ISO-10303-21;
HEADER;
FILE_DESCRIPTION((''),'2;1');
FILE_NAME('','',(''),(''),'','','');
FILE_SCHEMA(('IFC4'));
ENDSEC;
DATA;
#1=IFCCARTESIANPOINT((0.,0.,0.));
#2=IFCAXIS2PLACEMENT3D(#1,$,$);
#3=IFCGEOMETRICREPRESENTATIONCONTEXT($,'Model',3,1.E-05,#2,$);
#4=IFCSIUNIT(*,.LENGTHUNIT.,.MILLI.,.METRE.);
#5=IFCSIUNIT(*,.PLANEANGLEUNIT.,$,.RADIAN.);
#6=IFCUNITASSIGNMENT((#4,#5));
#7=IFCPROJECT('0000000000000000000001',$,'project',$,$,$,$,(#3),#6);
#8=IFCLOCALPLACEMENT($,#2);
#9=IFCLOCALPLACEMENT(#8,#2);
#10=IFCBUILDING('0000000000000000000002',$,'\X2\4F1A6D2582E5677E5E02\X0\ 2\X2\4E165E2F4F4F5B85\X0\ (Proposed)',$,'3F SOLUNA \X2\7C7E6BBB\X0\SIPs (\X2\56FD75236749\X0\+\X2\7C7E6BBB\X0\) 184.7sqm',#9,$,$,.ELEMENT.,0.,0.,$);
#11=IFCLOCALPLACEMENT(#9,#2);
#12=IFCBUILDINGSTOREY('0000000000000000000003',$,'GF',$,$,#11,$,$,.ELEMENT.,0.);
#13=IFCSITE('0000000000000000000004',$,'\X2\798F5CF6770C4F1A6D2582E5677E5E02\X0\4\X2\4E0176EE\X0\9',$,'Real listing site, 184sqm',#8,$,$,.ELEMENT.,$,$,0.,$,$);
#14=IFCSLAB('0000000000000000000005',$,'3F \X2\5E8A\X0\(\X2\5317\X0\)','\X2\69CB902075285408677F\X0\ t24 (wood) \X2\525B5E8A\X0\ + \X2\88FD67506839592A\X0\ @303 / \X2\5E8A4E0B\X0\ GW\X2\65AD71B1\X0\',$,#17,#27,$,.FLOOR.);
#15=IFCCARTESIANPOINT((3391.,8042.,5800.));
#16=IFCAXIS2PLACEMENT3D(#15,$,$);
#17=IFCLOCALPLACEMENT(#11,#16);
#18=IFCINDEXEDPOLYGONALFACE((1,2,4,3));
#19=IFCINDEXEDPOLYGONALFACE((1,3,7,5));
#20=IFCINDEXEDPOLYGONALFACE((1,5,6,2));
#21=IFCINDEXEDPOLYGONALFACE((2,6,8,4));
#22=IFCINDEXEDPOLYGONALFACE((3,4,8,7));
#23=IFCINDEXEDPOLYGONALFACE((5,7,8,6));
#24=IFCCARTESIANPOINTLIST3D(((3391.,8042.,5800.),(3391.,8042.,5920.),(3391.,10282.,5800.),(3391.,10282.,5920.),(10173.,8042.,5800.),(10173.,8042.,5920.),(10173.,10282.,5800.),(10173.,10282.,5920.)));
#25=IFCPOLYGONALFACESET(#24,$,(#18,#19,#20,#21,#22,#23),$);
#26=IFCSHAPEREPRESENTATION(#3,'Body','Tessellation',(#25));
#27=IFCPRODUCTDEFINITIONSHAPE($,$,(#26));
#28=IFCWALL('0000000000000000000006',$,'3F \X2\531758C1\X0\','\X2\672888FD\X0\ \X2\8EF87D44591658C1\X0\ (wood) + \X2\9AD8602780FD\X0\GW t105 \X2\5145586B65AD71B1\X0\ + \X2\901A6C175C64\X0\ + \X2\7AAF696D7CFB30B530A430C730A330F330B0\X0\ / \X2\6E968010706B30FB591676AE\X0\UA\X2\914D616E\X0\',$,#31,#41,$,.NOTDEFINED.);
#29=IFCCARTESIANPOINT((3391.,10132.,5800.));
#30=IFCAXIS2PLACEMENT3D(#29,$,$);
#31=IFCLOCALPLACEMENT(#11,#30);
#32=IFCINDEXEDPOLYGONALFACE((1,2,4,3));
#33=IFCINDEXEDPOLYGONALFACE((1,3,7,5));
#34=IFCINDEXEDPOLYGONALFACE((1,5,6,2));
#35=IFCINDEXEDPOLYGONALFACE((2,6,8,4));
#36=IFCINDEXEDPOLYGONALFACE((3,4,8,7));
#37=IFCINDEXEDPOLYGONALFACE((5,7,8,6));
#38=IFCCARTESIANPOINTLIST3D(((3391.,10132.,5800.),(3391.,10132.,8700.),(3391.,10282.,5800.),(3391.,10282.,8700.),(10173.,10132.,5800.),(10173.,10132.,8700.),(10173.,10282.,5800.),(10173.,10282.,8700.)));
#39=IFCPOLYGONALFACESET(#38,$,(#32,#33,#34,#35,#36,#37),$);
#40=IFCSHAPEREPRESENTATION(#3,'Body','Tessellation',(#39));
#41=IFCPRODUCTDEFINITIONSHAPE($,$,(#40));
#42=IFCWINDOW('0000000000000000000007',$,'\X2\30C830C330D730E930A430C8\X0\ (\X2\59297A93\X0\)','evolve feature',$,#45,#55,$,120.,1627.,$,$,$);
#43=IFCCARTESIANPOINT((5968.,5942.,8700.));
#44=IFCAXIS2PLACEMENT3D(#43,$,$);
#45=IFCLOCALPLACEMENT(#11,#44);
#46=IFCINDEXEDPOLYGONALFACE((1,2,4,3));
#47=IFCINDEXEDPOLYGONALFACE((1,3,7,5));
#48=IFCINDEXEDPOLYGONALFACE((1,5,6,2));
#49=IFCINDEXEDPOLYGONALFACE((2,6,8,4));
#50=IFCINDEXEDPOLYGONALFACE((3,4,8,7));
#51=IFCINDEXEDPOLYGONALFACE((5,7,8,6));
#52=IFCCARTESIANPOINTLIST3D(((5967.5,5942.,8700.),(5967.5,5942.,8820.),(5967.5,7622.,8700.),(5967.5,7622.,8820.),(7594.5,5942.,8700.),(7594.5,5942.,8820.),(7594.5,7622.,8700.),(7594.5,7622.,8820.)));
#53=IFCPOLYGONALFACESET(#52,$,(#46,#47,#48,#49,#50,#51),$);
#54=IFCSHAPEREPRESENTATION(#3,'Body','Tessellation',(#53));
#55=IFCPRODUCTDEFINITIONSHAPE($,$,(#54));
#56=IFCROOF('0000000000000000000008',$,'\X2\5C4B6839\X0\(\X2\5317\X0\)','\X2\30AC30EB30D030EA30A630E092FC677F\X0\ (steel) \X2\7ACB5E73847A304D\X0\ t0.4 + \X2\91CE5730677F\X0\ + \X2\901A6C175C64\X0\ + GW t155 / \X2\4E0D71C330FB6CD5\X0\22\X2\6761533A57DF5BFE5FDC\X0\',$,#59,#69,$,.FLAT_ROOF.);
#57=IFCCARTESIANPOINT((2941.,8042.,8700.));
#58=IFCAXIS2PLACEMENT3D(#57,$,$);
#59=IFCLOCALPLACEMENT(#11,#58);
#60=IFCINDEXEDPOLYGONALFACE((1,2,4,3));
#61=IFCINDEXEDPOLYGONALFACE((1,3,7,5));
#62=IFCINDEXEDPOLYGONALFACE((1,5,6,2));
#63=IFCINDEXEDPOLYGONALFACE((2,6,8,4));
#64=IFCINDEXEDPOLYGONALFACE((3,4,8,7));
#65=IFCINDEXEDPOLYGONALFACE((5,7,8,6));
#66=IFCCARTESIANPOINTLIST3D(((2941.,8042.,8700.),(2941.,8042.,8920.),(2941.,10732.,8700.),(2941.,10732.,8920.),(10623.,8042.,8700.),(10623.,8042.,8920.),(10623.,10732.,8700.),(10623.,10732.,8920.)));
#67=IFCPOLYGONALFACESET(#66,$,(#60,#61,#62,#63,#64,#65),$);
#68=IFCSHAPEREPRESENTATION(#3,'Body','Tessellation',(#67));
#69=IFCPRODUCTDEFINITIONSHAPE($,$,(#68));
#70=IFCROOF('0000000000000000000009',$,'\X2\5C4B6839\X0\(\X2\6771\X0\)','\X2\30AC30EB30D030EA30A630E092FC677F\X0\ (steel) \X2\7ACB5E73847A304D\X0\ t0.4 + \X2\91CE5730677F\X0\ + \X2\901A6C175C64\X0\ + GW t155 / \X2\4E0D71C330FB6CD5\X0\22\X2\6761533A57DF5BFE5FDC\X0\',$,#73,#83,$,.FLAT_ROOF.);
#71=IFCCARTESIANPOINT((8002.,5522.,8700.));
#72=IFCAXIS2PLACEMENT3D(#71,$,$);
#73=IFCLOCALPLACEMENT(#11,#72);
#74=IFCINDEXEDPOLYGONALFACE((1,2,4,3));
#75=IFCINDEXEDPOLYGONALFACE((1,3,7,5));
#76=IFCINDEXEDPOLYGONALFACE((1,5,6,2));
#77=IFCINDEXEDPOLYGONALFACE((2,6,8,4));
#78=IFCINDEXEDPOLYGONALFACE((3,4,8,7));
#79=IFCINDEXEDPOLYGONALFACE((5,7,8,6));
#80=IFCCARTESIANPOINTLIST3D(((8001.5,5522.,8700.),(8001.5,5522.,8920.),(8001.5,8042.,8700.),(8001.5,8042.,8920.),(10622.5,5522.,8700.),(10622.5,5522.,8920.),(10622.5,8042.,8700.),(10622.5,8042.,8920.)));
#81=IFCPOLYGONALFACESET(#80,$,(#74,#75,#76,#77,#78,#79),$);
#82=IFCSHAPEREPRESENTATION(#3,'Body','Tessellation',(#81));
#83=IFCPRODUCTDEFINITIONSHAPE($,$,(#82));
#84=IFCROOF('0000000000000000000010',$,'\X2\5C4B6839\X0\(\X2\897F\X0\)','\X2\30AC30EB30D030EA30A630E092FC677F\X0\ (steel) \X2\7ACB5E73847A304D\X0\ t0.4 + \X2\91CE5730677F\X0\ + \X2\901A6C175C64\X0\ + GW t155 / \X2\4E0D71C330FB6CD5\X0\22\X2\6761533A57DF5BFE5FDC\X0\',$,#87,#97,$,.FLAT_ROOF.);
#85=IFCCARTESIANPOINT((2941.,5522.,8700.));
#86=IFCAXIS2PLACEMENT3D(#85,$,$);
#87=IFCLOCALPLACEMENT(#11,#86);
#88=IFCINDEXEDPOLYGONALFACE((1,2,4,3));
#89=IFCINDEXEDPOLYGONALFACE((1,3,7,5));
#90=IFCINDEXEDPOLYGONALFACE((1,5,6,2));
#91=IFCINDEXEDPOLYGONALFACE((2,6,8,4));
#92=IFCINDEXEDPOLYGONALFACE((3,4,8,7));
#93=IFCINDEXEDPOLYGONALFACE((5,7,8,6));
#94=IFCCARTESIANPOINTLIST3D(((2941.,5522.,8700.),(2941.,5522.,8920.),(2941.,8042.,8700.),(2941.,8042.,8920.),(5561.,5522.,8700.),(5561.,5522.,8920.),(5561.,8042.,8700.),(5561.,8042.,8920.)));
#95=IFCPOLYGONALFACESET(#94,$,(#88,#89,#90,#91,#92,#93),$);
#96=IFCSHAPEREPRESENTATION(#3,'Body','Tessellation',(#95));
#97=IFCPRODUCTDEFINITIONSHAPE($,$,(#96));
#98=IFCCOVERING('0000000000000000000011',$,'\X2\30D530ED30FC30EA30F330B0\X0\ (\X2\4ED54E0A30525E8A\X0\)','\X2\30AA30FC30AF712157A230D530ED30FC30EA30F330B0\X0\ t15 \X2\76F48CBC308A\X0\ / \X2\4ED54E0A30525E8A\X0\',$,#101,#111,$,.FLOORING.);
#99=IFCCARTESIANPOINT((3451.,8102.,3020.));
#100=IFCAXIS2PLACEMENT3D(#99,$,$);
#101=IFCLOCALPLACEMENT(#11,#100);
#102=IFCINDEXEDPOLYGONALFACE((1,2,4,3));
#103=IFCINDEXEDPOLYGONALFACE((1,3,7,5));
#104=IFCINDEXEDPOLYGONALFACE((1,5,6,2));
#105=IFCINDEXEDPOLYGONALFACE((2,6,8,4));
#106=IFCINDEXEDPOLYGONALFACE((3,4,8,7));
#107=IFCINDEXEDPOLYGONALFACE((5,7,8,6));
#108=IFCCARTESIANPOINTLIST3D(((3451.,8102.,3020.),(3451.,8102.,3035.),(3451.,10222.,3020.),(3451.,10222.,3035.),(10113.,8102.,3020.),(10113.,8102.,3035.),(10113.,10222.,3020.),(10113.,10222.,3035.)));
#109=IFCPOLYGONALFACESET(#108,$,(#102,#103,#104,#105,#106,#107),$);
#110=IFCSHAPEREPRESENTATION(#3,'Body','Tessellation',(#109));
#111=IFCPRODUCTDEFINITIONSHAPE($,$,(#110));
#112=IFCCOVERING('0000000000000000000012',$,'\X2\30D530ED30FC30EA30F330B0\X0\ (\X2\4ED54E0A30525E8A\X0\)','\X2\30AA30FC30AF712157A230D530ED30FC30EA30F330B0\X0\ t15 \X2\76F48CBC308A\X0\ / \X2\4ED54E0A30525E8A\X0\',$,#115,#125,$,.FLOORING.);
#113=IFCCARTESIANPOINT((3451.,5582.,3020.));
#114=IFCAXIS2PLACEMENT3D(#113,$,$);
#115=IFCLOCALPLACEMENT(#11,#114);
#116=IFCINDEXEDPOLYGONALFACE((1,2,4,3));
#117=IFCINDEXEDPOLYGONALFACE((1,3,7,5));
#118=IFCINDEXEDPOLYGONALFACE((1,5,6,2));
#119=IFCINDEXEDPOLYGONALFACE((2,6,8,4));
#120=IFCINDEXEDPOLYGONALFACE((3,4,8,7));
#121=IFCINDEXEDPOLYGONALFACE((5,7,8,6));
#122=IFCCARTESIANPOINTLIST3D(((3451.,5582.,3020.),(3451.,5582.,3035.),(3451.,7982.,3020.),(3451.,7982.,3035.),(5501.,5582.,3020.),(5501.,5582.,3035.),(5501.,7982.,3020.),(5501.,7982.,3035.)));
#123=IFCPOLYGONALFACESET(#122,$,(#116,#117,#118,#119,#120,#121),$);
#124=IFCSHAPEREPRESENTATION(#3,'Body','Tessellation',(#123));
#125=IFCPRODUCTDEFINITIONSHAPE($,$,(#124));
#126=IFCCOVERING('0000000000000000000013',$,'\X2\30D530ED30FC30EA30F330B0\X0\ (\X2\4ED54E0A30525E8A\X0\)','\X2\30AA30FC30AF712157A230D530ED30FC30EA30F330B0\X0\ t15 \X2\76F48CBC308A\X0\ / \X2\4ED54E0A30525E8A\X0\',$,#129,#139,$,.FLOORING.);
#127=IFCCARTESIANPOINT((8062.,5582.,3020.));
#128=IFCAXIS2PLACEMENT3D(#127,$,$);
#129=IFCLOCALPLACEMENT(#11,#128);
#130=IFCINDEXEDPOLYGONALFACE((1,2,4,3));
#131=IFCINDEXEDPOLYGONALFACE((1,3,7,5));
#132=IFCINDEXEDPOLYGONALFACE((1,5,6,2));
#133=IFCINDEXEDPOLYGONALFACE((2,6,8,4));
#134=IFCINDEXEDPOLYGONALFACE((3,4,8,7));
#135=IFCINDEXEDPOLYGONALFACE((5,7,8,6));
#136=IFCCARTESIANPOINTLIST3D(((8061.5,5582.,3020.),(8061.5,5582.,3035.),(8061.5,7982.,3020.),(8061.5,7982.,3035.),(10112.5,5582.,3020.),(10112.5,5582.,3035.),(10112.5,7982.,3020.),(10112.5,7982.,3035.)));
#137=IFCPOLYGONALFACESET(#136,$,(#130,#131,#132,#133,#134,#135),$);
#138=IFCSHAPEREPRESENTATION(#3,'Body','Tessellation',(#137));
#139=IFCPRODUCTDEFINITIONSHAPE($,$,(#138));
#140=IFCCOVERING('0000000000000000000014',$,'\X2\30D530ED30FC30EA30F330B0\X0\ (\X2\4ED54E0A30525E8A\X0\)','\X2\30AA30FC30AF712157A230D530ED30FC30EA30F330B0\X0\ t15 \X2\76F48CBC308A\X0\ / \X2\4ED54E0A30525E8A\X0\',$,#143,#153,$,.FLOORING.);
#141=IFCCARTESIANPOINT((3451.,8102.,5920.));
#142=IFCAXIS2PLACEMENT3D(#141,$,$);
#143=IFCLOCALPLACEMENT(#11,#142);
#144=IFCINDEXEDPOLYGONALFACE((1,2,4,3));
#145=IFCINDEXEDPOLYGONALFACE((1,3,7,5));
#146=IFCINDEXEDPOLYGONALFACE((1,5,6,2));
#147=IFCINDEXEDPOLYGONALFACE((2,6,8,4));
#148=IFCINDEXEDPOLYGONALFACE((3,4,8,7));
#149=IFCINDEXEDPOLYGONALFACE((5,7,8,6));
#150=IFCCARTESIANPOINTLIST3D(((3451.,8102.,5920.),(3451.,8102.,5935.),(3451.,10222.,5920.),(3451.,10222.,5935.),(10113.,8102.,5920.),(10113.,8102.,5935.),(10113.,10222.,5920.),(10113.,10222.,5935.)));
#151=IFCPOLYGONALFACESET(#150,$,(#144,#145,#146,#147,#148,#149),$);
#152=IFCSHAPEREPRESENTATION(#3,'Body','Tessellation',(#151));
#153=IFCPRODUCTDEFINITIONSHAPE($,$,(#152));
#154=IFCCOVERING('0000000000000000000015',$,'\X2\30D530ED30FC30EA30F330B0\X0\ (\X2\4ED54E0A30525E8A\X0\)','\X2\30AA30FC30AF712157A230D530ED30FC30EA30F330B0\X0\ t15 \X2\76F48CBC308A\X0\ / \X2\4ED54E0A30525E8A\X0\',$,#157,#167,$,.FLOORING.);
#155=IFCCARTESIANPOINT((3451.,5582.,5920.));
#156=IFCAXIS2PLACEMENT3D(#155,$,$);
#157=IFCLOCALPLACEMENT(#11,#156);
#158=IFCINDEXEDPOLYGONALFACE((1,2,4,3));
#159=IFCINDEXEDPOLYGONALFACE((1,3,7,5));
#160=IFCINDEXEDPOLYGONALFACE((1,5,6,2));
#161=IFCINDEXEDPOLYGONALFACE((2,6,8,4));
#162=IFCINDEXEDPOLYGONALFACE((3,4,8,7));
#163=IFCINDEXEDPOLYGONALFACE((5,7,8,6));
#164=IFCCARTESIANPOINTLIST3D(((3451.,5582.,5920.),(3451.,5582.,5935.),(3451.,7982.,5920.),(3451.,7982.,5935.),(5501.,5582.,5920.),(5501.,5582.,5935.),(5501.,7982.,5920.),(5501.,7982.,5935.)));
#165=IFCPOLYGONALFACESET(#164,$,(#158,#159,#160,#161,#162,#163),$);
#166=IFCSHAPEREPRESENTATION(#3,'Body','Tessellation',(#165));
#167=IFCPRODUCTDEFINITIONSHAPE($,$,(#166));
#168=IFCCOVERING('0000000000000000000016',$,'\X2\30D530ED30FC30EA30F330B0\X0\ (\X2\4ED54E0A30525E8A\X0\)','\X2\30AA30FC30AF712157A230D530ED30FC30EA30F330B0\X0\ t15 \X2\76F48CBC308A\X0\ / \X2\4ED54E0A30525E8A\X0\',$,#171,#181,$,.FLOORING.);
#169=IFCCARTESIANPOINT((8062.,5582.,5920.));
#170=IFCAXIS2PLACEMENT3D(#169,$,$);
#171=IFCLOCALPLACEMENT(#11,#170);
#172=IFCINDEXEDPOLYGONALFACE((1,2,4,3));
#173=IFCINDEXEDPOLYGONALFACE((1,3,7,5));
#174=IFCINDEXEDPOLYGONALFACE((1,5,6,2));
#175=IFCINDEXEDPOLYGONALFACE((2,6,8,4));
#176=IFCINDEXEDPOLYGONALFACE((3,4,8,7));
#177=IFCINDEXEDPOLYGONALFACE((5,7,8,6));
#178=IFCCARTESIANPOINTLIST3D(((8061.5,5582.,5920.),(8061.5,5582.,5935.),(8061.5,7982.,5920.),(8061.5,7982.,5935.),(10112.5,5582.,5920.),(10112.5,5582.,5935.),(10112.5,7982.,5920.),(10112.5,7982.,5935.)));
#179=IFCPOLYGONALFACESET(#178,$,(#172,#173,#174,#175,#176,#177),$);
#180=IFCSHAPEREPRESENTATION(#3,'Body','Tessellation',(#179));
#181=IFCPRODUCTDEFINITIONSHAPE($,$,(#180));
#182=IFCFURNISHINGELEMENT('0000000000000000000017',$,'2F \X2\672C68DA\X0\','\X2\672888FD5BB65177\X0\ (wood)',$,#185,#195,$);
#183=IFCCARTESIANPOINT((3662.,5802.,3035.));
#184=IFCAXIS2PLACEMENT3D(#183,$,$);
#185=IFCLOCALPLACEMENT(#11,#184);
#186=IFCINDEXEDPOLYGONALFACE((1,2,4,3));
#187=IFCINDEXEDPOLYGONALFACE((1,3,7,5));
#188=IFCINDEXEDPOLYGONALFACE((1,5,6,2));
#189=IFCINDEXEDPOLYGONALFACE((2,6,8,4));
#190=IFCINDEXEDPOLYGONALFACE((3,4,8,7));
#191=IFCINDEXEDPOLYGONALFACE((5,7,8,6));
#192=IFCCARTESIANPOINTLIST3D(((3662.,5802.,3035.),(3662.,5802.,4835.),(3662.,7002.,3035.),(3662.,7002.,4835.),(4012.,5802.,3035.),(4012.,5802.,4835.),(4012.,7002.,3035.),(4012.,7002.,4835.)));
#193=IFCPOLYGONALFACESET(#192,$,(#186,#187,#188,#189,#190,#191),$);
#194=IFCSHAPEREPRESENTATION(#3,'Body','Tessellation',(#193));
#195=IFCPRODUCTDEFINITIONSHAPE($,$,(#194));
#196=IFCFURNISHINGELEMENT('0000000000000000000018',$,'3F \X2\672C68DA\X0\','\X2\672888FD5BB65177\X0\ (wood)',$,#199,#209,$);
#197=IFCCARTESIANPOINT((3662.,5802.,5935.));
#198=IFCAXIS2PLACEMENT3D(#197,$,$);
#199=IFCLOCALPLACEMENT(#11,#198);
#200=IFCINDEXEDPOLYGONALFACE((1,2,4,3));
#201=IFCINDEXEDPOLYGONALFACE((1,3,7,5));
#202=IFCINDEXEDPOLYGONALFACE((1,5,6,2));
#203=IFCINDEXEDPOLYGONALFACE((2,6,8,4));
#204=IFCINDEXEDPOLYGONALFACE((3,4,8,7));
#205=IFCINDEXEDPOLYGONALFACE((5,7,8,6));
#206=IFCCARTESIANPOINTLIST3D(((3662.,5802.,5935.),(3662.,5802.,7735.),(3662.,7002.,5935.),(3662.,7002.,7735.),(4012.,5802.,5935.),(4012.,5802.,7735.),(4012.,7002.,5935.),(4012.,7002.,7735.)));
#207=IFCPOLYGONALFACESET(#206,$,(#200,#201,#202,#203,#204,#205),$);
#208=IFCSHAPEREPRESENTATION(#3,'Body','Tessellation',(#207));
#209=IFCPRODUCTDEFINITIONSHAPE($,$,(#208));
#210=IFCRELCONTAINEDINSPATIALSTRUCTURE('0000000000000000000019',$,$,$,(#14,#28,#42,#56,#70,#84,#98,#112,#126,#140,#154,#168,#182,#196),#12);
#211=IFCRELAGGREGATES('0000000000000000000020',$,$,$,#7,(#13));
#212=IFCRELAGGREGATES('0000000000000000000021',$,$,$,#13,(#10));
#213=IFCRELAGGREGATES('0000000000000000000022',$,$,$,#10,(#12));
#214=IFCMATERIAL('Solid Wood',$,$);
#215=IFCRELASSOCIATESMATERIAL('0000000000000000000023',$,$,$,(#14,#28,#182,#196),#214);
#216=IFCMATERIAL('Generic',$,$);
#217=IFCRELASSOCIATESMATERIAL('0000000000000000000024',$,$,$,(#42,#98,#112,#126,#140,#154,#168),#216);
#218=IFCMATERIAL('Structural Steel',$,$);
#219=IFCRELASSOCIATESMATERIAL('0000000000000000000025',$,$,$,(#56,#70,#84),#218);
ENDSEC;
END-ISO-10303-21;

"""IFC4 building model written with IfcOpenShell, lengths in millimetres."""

from ifc_helpers import new_model, si_unit, frame, frame_2d, origin, place, context, project, spatial, rectangle, extrude, material, element, save


model = new_model("IFC4")

# Units and contexts
model_context = context("Model", 3, precision=1e-05, world=origin())
ifc_project = project(units=[si_unit("LENGTHUNIT", "METRE", prefix="MILLI"), si_unit("PLANEANGLEUNIT", "RADIAN")], contexts=[model_context])

# Site, building, storey
site_placement = place(None, origin())
site = spatial("IfcSite", under=ifc_project, at=site_placement, Name="福島県会津若松市4丁目9", ObjectType="Real listing site, 184sqm", CompositionType="ELEMENT", RefElevation=0.0)
building_placement = place(site_placement, origin())
building = spatial("IfcBuilding", under=site, at=building_placement, Name="会津若松市 2世帯住宅 (Proposed)", ObjectType="3F SOLUNA 籾殻SIPs (国産杉+籾殻) 184.7sqm", CompositionType="ELEMENT", ElevationOfRefHeight=0.0, ElevationOfTerrain=0.0)
storey_placement = place(building_placement, origin())
storey = spatial("IfcBuildingStorey", under=building, at=storey_placement, Name="GF", CompositionType="ELEMENT", Elevation=0.0)

# Slab
ifc_material_1 = material(Name="Solid Wood")
slab_placement = place(storey_placement, frame((3391.0, 8042.0, 5800.0)))
element("IfcSlab", 1, at=slab_placement, inside=storey, material=ifc_material_1, Name="3F 床(北)", Description="構造用合板 t24 (wood) 剛床 + 製材根太 @303 / 床下 GW断熱", PredefinedType="FLOOR", context=model_context, shape_type="SweptSolid", body=[
    extrude(rectangle(XDim=6782.0, YDim=2240.0, at=frame_2d((3391.0, 1120.0))), frame((3391.0, 8042.0, 5800.0)), (0.0, 0.0, 1.0), 120.0),
])

# Wall
wall_1_placement = place(storey_placement, frame((3391.0, 10132.0, 5800.0)))
element("IfcWall", 2, at=wall_1_placement, inside=storey, material=ifc_material_1, Name="3F 北壁", Description="木製 軸組外壁 (wood) + 高性能GW t105 充填断熱 + 通気層 + 窯業系サイディング / 準耐火・外皮UA配慮", PredefinedType="NOTDEFINED", context=model_context, shape_type="SweptSolid", body=[
    extrude(rectangle(XDim=6782.0, YDim=150.0, at=frame_2d((3391.0, 75.0))), frame((3391.0, 10132.0, 5800.0)), (0.0, 0.0, 1.0), 2900.0),
])

# Window
ifc_material_2 = material(Name="Generic")
window_1_placement = place(storey_placement, frame((5968.0, 5942.0, 8700.0)))
element("IfcWindow", 3, at=window_1_placement, inside=storey, material=ifc_material_2, Name="トップライト (天窓)", Description="evolve feature", OverallHeight=120.0, OverallWidth=1627.0, context=model_context, shape_type="SweptSolid", body=[
    extrude(rectangle(XDim=1627.0, YDim=1680.0, at=frame_2d((813.0, 840.0))), frame((5968.0, 5942.0, 8700.0)), (0.0, 0.0, 1.0), 120.0),
])

# Roofs
ifc_material_3 = material(Name="Structural Steel")
roof_1_placement = place(storey_placement, frame((2941.0, 8042.0, 8700.0)))
element("IfcRoof", 4, at=roof_1_placement, inside=storey, material=ifc_material_3, Name="屋根(北)", Description="ガルバリウム鋼板 (steel) 立平葺き t0.4 + 野地板 + 通気層 + GW t155 / 不燃・法22条区域対応", PredefinedType="FLAT_ROOF", context=model_context, shape_type="SweptSolid", body=[
    extrude(rectangle(XDim=7682.0, YDim=2690.0, at=frame_2d((3841.0, 1345.0))), frame((2941.0, 8042.0, 8700.0)), (0.0, 0.0, 1.0), 220.0),
])
roof_2_placement = place(storey_placement, frame((8002.0, 5522.0, 8700.0)))
element("IfcRoof", 5, at=roof_2_placement, inside=storey, material=ifc_material_3, Name="屋根(東)", Description="ガルバリウム鋼板 (steel) 立平葺き t0.4 + 野地板 + 通気層 + GW t155 / 不燃・法22条区域対応", PredefinedType="FLAT_ROOF", context=model_context, shape_type="SweptSolid", body=[
    extrude(rectangle(XDim=2621.0, YDim=2520.0, at=frame_2d((1310.0, 1260.0))), frame((8002.0, 5522.0, 8700.0)), (0.0, 0.0, 1.0), 220.0),
])
roof_3_placement = place(storey_placement, frame((2941.0, 5522.0, 8700.0)))
element("IfcRoof", 6, at=roof_3_placement, inside=storey, material=ifc_material_3, Name="屋根(西)", Description="ガルバリウム鋼板 (steel) 立平葺き t0.4 + 野地板 + 通気層 + GW t155 / 不燃・法22条区域対応", PredefinedType="FLAT_ROOF", context=model_context, shape_type="SweptSolid", body=[
    extrude(rectangle(XDim=2620.0, YDim=2520.0, at=frame_2d((1310.0, 1260.0))), frame((2941.0, 5522.0, 8700.0)), (0.0, 0.0, 1.0), 220.0),
])

# Coverings
covering_1_placement = place(storey_placement, frame((3451.0, 8102.0, 3020.0)))
element("IfcCovering", 7, at=covering_1_placement, inside=storey, material=ifc_material_2, Name="フローリング (仕上げ床)", Description="オーク無垢フローリング t15 直貼り / 仕上げ床", PredefinedType="FLOORING", context=model_context, shape_type="SweptSolid", body=[
    extrude(rectangle(XDim=6662.0, YDim=2120.0, at=frame_2d((3331.0, 1060.0))), frame((3451.0, 8102.0, 3020.0)), (0.0, 0.0, 1.0), 15.0),
])
covering_2_placement = place(storey_placement, frame((3451.0, 5582.0, 3020.0)))
element("IfcCovering", 8, at=covering_2_placement, inside=storey, material=ifc_material_2, Name="フローリング (仕上げ床)", Description="オーク無垢フローリング t15 直貼り / 仕上げ床", PredefinedType="FLOORING", context=model_context, shape_type="SweptSolid", body=[
    extrude(rectangle(XDim=2050.0, YDim=2400.0, at=frame_2d((1025.0, 1200.0))), frame((3451.0, 5582.0, 3020.0)), (0.0, 0.0, 1.0), 15.0),
])
covering_3_placement = place(storey_placement, frame((8062.0, 5582.0, 3020.0)))
element("IfcCovering", 9, at=covering_3_placement, inside=storey, material=ifc_material_2, Name="フローリング (仕上げ床)", Description="オーク無垢フローリング t15 直貼り / 仕上げ床", PredefinedType="FLOORING", context=model_context, shape_type="SweptSolid", body=[
    extrude(rectangle(XDim=2051.0, YDim=2400.0, at=frame_2d((1025.0, 1200.0))), frame((8062.0, 5582.0, 3020.0)), (0.0, 0.0, 1.0), 15.0),
])
covering_4_placement = place(storey_placement, frame((3451.0, 8102.0, 5920.0)))
element("IfcCovering", 10, at=covering_4_placement, inside=storey, material=ifc_material_2, Name="フローリング (仕上げ床)", Description="オーク無垢フローリング t15 直貼り / 仕上げ床", PredefinedType="FLOORING", context=model_context, shape_type="SweptSolid", body=[
    extrude(rectangle(XDim=6662.0, YDim=2120.0, at=frame_2d((3331.0, 1060.0))), frame((3451.0, 8102.0, 5920.0)), (0.0, 0.0, 1.0), 15.0),
])
covering_5_placement = place(storey_placement, frame((3451.0, 5582.0, 5920.0)))
element("IfcCovering", 11, at=covering_5_placement, inside=storey, material=ifc_material_2, Name="フローリング (仕上げ床)", Description="オーク無垢フローリング t15 直貼り / 仕上げ床", PredefinedType="FLOORING", context=model_context, shape_type="SweptSolid", body=[
    extrude(rectangle(XDim=2050.0, YDim=2400.0, at=frame_2d((1025.0, 1200.0))), frame((3451.0, 5582.0, 5920.0)), (0.0, 0.0, 1.0), 15.0),
])
covering_6_placement = place(storey_placement, frame((8062.0, 5582.0, 5920.0)))
element("IfcCovering", 12, at=covering_6_placement, inside=storey, material=ifc_material_2, Name="フローリング (仕上げ床)", Description="オーク無垢フローリング t15 直貼り / 仕上げ床", PredefinedType="FLOORING", context=model_context, shape_type="SweptSolid", body=[
    extrude(rectangle(XDim=2051.0, YDim=2400.0, at=frame_2d((1025.0, 1200.0))), frame((8062.0, 5582.0, 5920.0)), (0.0, 0.0, 1.0), 15.0),
])

# Furnishing elements
furnishing_1_placement = place(storey_placement, frame((3662.0, 5802.0, 3035.0)))
element("IfcFurnishingElement", 13, at=furnishing_1_placement, inside=storey, material=ifc_material_1, Name="2F 本棚", Description="木製家具 (wood)", context=model_context, shape_type="SweptSolid", body=[
    extrude(rectangle(XDim=350.0, YDim=1200.0, at=frame_2d((175.0, 600.0))), frame((3662.0, 5802.0, 3035.0)), (0.0, 0.0, 1.0), 1800.0),
])
furnishing_2_placement = place(storey_placement, frame((3662.0, 5802.0, 5935.0)))
element("IfcFurnishingElement", 14, at=furnishing_2_placement, inside=storey, material=ifc_material_1, Name="3F 本棚", Description="木製家具 (wood)", context=model_context, shape_type="SweptSolid", body=[
    extrude(rectangle(XDim=350.0, YDim=1200.0, at=frame_2d((175.0, 600.0))), frame((3662.0, 5802.0, 5935.0)), (0.0, 0.0, 1.0), 1800.0),
])

save(model, "model.ifc")
